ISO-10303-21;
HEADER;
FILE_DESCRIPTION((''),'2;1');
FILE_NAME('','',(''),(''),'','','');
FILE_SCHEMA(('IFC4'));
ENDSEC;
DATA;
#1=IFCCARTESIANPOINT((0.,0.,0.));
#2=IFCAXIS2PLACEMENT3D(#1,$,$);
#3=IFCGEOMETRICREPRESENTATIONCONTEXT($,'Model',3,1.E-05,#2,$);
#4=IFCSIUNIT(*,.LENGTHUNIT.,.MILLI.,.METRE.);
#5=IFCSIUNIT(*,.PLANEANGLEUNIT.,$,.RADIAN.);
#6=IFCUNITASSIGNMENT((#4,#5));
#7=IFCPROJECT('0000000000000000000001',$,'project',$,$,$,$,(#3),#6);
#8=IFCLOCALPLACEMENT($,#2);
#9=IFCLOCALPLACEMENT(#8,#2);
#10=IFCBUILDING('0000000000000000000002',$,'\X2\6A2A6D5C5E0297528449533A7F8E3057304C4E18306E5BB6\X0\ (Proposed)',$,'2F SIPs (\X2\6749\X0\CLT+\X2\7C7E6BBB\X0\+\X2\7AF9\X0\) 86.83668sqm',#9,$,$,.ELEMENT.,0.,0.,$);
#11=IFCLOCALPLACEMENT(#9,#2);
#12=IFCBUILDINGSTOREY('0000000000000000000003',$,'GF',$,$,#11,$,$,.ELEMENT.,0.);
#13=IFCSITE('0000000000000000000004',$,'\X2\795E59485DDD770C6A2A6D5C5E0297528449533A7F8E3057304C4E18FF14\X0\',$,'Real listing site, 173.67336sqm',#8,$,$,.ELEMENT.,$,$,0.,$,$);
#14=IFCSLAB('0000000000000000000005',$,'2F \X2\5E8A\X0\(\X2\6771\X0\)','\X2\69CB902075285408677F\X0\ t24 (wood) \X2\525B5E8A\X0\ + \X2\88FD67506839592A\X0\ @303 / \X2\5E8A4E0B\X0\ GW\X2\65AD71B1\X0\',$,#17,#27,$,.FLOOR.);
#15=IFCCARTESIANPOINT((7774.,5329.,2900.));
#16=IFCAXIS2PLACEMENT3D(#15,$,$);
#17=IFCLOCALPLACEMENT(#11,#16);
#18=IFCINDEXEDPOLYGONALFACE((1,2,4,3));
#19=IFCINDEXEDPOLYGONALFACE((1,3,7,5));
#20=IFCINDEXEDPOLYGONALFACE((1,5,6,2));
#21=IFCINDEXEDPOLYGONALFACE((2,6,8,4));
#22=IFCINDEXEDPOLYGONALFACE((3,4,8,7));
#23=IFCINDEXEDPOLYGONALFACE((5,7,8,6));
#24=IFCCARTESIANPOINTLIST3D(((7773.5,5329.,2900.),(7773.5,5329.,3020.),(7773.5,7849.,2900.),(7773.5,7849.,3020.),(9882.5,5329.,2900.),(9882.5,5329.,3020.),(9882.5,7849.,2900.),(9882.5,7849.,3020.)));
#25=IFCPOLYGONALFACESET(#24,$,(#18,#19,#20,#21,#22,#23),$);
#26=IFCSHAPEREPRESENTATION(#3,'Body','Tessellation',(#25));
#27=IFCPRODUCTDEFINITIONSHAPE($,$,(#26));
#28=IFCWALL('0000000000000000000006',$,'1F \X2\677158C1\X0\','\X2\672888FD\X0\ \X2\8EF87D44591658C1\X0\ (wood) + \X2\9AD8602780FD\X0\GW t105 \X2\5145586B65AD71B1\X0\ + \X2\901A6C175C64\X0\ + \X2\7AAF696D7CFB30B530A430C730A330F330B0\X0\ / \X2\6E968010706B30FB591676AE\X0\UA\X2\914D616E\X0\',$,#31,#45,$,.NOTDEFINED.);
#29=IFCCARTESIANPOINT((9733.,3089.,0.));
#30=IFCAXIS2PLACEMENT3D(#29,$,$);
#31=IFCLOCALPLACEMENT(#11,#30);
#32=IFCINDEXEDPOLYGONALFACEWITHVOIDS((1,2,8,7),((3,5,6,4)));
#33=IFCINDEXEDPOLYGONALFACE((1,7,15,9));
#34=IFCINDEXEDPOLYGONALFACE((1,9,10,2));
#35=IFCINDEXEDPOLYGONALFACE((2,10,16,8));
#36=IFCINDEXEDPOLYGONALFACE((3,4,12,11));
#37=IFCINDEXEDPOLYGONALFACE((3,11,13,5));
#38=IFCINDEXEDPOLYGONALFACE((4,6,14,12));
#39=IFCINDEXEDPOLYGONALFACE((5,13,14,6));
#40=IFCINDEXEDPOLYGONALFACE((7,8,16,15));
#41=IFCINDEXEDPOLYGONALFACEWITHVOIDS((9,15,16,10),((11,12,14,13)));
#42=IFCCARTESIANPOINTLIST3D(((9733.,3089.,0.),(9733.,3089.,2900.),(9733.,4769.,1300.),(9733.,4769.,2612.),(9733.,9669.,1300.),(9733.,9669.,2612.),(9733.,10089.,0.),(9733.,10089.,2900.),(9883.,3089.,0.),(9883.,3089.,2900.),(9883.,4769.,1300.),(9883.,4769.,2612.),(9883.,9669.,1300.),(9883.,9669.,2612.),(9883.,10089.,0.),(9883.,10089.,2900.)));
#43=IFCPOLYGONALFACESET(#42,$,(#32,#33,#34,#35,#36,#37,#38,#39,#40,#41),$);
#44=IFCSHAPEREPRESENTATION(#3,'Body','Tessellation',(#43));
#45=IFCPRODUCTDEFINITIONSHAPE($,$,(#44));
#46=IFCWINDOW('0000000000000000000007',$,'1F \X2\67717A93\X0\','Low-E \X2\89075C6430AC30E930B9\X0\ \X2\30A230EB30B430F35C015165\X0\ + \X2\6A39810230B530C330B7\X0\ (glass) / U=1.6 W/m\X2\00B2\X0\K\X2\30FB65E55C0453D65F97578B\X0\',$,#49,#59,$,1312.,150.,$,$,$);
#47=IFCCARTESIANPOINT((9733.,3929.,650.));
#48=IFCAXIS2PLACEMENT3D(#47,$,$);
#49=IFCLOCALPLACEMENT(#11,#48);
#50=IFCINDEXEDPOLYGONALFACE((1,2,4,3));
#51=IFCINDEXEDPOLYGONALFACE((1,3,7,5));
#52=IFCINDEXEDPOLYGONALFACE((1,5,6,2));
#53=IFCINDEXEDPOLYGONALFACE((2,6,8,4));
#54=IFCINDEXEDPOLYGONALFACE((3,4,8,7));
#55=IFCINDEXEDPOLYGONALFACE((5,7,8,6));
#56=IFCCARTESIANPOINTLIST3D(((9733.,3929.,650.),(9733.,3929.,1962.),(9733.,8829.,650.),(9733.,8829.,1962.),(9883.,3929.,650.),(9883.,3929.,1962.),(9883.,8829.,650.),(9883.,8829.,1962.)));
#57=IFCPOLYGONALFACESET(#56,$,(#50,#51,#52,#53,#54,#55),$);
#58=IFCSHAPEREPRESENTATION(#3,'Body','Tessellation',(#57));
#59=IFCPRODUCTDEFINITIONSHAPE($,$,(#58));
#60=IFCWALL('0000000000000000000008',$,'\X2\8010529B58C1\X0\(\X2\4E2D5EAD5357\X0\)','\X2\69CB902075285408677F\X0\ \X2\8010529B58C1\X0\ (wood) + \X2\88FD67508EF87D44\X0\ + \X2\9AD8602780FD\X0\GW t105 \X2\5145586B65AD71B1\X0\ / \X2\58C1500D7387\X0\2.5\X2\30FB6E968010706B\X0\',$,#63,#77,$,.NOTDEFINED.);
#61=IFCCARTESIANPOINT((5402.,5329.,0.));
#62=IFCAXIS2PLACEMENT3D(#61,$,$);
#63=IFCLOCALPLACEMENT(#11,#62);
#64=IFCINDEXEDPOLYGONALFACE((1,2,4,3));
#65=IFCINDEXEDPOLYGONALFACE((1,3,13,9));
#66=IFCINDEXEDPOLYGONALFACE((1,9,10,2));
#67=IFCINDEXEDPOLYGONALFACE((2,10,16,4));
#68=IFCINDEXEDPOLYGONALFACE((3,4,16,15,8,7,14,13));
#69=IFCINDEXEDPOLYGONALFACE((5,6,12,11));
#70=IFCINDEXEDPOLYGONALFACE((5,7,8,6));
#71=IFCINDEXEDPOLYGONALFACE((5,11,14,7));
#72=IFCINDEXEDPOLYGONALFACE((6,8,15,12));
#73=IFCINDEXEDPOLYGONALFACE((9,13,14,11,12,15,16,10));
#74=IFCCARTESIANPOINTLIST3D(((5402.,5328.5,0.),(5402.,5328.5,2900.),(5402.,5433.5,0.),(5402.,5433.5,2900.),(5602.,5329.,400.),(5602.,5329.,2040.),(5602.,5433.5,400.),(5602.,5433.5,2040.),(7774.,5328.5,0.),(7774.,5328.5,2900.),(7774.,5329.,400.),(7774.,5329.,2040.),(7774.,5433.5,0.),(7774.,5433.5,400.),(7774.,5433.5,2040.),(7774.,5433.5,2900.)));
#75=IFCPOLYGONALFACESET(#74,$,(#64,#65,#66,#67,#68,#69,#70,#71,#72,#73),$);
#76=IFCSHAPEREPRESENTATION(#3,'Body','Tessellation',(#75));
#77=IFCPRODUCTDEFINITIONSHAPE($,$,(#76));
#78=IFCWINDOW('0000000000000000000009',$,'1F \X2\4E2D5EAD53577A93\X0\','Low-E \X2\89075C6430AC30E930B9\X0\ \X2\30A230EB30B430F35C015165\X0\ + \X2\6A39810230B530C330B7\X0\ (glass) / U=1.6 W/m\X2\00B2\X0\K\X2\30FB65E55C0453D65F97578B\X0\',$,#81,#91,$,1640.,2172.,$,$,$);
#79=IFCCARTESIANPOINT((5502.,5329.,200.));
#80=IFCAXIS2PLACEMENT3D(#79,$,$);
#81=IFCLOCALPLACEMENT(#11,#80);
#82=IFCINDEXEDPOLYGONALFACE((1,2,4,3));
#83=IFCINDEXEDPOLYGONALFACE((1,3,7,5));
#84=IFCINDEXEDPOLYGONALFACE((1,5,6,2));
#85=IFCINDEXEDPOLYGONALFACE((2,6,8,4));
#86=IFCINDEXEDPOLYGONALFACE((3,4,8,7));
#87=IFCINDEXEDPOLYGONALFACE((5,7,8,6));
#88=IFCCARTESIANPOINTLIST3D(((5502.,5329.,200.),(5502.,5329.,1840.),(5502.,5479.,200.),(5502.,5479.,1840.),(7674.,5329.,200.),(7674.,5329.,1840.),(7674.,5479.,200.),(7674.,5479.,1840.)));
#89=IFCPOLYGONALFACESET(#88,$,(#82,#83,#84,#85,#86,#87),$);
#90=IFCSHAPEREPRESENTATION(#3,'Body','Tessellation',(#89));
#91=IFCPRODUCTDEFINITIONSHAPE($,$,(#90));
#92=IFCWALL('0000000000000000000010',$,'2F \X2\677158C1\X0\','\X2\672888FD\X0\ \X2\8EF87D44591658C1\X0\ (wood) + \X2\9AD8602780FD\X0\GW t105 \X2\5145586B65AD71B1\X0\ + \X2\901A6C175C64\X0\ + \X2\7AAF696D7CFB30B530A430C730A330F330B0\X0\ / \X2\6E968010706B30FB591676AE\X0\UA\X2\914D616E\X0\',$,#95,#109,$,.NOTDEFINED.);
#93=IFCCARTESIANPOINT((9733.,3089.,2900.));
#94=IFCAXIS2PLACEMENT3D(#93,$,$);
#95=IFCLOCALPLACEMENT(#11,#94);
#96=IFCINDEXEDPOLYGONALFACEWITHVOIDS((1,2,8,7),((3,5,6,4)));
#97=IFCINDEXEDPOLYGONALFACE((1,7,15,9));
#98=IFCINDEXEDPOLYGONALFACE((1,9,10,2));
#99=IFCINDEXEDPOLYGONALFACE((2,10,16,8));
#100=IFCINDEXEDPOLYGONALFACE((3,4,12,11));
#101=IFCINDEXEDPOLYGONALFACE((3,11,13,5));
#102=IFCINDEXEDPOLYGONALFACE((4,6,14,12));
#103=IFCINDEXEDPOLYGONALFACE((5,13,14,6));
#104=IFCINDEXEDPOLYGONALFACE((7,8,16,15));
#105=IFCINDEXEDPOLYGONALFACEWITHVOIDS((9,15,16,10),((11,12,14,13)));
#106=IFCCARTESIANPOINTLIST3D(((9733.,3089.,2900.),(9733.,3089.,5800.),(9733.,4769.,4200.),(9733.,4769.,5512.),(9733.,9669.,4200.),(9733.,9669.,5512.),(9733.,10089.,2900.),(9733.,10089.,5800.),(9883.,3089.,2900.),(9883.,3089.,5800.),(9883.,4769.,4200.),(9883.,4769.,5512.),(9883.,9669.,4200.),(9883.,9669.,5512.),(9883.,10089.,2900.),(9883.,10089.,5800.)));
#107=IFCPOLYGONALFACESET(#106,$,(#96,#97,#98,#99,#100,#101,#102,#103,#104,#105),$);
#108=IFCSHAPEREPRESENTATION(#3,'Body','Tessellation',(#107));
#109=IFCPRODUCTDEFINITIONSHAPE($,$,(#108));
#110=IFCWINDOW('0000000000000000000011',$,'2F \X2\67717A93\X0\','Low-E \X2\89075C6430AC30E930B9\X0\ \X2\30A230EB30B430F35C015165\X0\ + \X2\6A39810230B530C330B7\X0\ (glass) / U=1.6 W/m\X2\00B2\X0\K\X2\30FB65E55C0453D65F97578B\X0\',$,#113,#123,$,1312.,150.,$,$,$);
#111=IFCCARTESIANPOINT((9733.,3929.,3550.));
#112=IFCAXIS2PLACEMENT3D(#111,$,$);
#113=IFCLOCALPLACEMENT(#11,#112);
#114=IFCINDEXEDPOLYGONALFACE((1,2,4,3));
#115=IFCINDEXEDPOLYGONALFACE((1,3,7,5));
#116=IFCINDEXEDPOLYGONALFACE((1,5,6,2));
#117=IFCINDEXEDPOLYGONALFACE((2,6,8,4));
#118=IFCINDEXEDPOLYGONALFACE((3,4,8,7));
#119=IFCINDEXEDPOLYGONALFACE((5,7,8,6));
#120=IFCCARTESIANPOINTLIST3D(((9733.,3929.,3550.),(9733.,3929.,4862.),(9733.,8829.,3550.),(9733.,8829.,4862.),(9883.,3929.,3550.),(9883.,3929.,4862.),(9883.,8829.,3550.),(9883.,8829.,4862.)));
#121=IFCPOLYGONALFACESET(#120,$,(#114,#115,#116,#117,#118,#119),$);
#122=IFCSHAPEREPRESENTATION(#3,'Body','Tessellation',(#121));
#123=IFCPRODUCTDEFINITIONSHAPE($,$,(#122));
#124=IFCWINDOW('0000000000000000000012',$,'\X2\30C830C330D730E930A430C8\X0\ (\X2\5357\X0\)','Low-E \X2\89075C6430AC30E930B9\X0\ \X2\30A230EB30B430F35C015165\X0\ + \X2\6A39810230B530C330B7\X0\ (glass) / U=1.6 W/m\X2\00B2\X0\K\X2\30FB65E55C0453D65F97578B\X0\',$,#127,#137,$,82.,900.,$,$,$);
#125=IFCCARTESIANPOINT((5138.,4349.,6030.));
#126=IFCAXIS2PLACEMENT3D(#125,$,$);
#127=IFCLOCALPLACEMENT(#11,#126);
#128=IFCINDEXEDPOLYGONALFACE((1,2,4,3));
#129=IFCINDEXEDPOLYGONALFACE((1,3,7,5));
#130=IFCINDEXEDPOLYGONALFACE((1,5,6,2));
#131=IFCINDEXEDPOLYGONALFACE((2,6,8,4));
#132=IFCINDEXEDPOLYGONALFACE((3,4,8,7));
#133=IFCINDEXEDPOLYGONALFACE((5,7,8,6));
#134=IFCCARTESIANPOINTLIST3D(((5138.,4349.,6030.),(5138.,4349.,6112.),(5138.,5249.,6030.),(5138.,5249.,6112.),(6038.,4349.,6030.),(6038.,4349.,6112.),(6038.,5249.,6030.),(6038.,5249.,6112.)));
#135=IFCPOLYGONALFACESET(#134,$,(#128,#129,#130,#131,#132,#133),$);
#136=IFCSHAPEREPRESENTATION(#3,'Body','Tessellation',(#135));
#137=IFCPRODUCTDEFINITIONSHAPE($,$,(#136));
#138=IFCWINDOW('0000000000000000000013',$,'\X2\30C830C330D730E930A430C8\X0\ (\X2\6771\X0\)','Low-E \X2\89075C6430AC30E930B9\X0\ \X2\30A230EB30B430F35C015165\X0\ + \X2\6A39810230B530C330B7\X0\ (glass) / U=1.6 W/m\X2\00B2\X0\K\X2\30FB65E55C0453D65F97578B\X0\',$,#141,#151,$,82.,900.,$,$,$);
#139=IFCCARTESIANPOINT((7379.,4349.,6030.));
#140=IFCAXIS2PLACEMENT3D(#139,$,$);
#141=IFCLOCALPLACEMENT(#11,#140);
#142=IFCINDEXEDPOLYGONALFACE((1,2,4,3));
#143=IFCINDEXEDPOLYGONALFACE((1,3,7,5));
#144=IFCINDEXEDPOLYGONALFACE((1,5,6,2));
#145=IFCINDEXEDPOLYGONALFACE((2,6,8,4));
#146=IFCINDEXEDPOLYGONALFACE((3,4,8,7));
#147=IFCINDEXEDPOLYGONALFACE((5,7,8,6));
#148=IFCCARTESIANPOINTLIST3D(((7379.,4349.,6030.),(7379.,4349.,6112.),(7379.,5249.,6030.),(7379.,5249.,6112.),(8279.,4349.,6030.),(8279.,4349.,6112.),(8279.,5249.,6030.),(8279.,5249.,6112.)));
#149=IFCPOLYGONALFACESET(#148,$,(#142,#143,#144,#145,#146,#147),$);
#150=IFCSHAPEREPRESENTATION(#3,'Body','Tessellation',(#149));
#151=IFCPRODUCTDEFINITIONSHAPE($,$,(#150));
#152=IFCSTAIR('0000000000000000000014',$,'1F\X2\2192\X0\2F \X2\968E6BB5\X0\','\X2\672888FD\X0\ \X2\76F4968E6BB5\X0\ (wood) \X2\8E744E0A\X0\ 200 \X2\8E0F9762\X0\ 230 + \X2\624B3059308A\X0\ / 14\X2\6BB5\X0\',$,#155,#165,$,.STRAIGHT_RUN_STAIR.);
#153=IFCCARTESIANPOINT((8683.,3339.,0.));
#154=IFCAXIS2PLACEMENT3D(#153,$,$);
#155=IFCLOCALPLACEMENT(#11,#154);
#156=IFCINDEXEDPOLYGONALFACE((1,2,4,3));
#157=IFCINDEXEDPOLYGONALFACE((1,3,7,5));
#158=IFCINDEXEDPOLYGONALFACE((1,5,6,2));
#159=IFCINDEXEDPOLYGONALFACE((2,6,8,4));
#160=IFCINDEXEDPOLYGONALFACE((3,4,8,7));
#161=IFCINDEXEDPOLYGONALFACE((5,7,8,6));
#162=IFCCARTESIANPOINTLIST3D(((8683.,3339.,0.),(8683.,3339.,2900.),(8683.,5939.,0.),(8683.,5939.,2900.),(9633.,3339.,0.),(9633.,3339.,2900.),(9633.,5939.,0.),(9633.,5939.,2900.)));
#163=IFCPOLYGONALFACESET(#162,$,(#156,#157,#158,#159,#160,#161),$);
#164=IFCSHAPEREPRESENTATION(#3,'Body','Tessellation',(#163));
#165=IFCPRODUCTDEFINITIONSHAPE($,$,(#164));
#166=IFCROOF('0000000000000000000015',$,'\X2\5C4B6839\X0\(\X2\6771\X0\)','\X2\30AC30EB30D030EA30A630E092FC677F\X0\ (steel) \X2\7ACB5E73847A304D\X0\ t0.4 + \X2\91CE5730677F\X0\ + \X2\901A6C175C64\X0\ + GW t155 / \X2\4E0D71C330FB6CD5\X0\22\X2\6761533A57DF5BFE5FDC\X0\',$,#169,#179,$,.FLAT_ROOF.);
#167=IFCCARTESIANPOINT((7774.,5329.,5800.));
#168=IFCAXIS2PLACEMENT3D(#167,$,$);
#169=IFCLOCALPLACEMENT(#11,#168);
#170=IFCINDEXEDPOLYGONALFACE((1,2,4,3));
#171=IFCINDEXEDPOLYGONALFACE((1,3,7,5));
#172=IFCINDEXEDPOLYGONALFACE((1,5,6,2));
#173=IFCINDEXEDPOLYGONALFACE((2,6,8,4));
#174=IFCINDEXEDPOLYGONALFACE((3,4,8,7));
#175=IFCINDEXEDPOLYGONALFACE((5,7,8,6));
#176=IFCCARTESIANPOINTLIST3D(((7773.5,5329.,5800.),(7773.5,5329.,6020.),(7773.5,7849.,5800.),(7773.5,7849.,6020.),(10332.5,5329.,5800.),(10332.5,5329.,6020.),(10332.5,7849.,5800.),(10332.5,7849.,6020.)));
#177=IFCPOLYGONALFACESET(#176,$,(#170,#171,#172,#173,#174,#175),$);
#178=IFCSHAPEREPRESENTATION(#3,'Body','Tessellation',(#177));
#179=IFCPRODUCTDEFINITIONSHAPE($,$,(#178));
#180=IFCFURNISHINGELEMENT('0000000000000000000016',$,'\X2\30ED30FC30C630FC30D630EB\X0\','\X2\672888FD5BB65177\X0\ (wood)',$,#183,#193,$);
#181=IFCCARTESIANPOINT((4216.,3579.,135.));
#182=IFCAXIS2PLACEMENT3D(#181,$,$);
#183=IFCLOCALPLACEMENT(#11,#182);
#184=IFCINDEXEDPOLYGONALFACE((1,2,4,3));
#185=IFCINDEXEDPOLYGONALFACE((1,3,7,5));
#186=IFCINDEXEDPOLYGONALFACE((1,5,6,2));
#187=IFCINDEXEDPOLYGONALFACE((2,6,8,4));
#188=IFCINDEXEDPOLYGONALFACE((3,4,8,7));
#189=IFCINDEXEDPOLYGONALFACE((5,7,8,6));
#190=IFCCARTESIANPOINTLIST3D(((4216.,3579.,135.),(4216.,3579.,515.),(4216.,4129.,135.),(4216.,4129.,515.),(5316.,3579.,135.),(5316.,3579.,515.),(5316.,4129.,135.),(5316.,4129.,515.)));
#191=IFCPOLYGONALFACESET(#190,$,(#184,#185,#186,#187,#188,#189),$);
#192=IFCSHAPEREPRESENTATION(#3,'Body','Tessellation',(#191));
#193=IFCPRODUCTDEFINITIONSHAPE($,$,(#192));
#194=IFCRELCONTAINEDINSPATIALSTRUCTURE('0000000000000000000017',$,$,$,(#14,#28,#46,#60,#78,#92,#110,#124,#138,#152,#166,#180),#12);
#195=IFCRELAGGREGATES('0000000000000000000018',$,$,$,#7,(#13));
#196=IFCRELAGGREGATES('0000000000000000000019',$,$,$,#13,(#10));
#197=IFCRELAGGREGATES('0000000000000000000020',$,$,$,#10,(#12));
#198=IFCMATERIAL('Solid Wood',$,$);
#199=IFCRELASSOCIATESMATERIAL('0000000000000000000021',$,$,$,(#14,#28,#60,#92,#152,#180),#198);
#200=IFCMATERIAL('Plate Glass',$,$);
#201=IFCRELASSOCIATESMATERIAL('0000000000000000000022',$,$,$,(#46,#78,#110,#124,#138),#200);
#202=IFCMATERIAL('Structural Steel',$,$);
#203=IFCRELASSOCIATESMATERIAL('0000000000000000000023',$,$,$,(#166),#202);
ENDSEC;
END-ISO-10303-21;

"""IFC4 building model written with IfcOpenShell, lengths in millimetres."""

from ifc_helpers import new_model, si_unit, frame, frame_2d, origin, place, context, project, spatial, rectangle, extrude, material, element, fill, save


model = new_model("IFC4")

# Units and contexts
model_context = context("Model", 3, precision=1e-05, world=origin())
ifc_project = project(units=[si_unit("LENGTHUNIT", "METRE", prefix="MILLI"), si_unit("PLANEANGLEUNIT", "RADIAN")], contexts=[model_context])

# Site, building, storey
site_placement = place(None, origin())
site = spatial("IfcSite", under=ifc_project, at=site_placement, Name="神奈川県横浜市青葉区美しが丘４", ObjectType="Real listing site, 173.67336sqm", CompositionType="ELEMENT", RefElevation=0.0)
building_placement = place(site_placement, origin())
building = spatial("IfcBuilding", under=site, at=building_placement, Name="横浜市青葉区美しが丘の家 (Proposed)", ObjectType="2F SIPs (杉CLT+籾殻+竹) 86.83668sqm", CompositionType="ELEMENT", ElevationOfRefHeight=0.0, ElevationOfTerrain=0.0)
storey_placement = place(building_placement, origin())
storey = spatial("IfcBuildingStorey", under=building, at=storey_placement, Name="GF", CompositionType="ELEMENT", Elevation=0.0)

# Slab
ifc_material_1 = material(Name="Solid Wood")
slab_1_placement = place(storey_placement, frame((7774.0, 5329.0, 2900.0)))
element("IfcSlab", 1, at=slab_1_placement, inside=storey, material=ifc_material_1, Name="2F 床(東)", Description="構造用合板 t24 (wood) 剛床 + 製材根太 @303 / 床下 GW断熱", PredefinedType="FLOOR", context=model_context, shape_type="SweptSolid", body=[
    extrude(rectangle(XDim=2109.0, YDim=2520.0, at=frame_2d((1054.0, 1260.0))), frame((7774.0, 5329.0, 2900.0)), (0.0, 0.0, 1.0), 120.0),
])

# Walls, openings, windows
wall_1_placement = place(storey_placement, frame((9733.0, 3089.0, 0.0)))
wall_1 = element("IfcWall", 2, at=wall_1_placement, inside=storey, material=ifc_material_1, Name="1F 東壁", Description="木製 軸組外壁 (wood) + 高性能GW t105 充填断熱 + 通気層 + 窯業系サイディング / 準耐火・外皮UA配慮", PredefinedType="NOTDEFINED", context=model_context, shape_type="SweptSolid", body=[
    extrude(rectangle(XDim=150.0, YDim=7000.0, at=frame_2d((75.0, 3500.0))), frame((9733.0, 3089.0, 0.0)), (0.0, 0.0, 1.0), 2900.0),
])
opening_1_placement = place(storey_placement, frame((9733.0, 3929.0, 650.0)))
opening_1 = element("IfcOpeningElement", 3, at=opening_1_placement, cuts=wall_1, PredefinedType="NOTDEFINED", context=model_context, shape_type="SweptSolid", body=[
    extrude(rectangle(XDim=150.0, YDim=4900.0, at=frame_2d((75.0, 2450.0))), frame((9733.0, 3929.0, 650.0)), (0.0, 0.0, 1.0), 1312.0),
])
ifc_material_2 = material(Name="Plate Glass")
window_1_placement = place(storey_placement, frame((9733.0, 3929.0, 650.0)))
window_1 = element("IfcWindow", 4, at=window_1_placement, inside=storey, material=ifc_material_2, Name="1F 東窓", Description="Low-E 複層ガラス アルゴン封入 + 樹脂サッシ (glass) / U=1.6 W/m²K・日射取得型", OverallHeight=1312.0, OverallWidth=150.0, context=model_context, shape_type="SweptSolid", body=[
    extrude(rectangle(XDim=150.0, YDim=4900.0, at=frame_2d((75.0, 2450.0))), frame((9733.0, 3929.0, 650.0)), (0.0, 0.0, 1.0), 1312.0),
])
fill(opening_1, window_1)
wall_2_placement = place(storey_placement, frame((5402.0, 5329.0, 0.0)))
wall_2 = element("IfcWall", 5, at=wall_2_placement, inside=storey, material=ifc_material_1, Name="耐力壁(中庭南)", Description="構造用合板 耐力壁 (wood) + 製材軸組 + 高性能GW t105 充填断熱 / 壁倍率2.5・準耐火", PredefinedType="NOTDEFINED", context=model_context, shape_type="SweptSolid", body=[
    extrude(rectangle(XDim=2372.0, YDim=105.0, at=frame_2d((1186.0, 52.0))), frame((5402.0, 5329.0, 0.0)), (0.0, 0.0, 1.0), 2900.0),
])
opening_2_placement = place(storey_placement, frame((5502.0, 5329.0, 200.0)))
opening_2 = element("IfcOpeningElement", 6, at=opening_2_placement, cuts=wall_2, PredefinedType="NOTDEFINED", context=model_context, shape_type="SweptSolid", body=[
    extrude(rectangle(XDim=2172.0, YDim=150.0, at=frame_2d((1086.0, 75.0))), frame((5502.0, 5329.0, 200.0)), (0.0, 0.0, 1.0), 1640.0),
])
window_2_placement = place(storey_placement, frame((5502.0, 5329.0, 200.0)))
window_2 = element("IfcWindow", 7, at=window_2_placement, inside=storey, material=ifc_material_2, Name="1F 中庭南窓", Description="Low-E 複層ガラス アルゴン封入 + 樹脂サッシ (glass) / U=1.6 W/m²K・日射取得型", OverallHeight=1640.0, OverallWidth=2172.0, context=model_context, shape_type="SweptSolid", body=[
    extrude(rectangle(XDim=2172.0, YDim=150.0, at=frame_2d((1086.0, 75.0))), frame((5502.0, 5329.0, 200.0)), (0.0, 0.0, 1.0), 1640.0),
])
fill(opening_2, window_2)

# Wall, opening, window
wall_3_placement = place(storey_placement, frame((9733.0, 3089.0, 2900.0)))
wall_3 = element("IfcWall", 8, at=wall_3_placement, inside=storey, material=ifc_material_1, Name="2F 東壁", Description="木製 軸組外壁 (wood) + 高性能GW t105 充填断熱 + 通気層 + 窯業系サイディング / 準耐火・外皮UA配慮", PredefinedType="NOTDEFINED", context=model_context, shape_type="SweptSolid", body=[
    extrude(rectangle(XDim=150.0, YDim=7000.0, at=frame_2d((75.0, 3500.0))), frame((9733.0, 3089.0, 2900.0)), (0.0, 0.0, 1.0), 2900.0),
])
opening_3_placement = place(storey_placement, frame((9733.0, 3929.0, 3550.0)))
opening_3 = element("IfcOpeningElement", 9, at=opening_3_placement, cuts=wall_3, PredefinedType="NOTDEFINED", context=model_context, shape_type="SweptSolid", body=[
    extrude(rectangle(XDim=150.0, YDim=4900.0, at=frame_2d((75.0, 2450.0))), frame((9733.0, 3929.0, 3550.0)), (0.0, 0.0, 1.0), 1312.0),
])
window_3_placement = place(storey_placement, frame((9733.0, 3929.0, 3550.0)))
window_3 = element("IfcWindow", 10, at=window_3_placement, inside=storey, material=ifc_material_2, Name="2F 東窓", Description="Low-E 複層ガラス アルゴン封入 + 樹脂サッシ (glass) / U=1.6 W/m²K・日射取得型", OverallHeight=1312.0, OverallWidth=150.0, context=model_context, shape_type="SweptSolid", body=[
    extrude(rectangle(XDim=150.0, YDim=4900.0, at=frame_2d((75.0, 2450.0))), frame((9733.0, 3929.0, 3550.0)), (0.0, 0.0, 1.0), 1312.0),
])
fill(opening_3, window_3)

# Windows
window_4_placement = place(storey_placement, frame((5138.0, 4349.0, 6030.0)))
element("IfcWindow", 11, at=window_4_placement, inside=storey, material=ifc_material_2, Name="トップライト (南)", Description="Low-E 複層ガラス アルゴン封入 + 樹脂サッシ (glass) / U=1.6 W/m²K・日射取得型", OverallHeight=82.0, OverallWidth=900.0, context=model_context, shape_type="SweptSolid", body=[
    extrude(rectangle(XDim=900.0, YDim=900.0, at=frame_2d((450.0, 450.0))), frame((5138.0, 4349.0, 6030.0)), (0.0, 0.0, 1.0), 82.0),
])
window_5_placement = place(storey_placement, frame((7379.0, 4349.0, 6030.0)))
element("IfcWindow", 12, at=window_5_placement, inside=storey, material=ifc_material_2, Name="トップライト (東)", Description="Low-E 複層ガラス アルゴン封入 + 樹脂サッシ (glass) / U=1.6 W/m²K・日射取得型", OverallHeight=82.0, OverallWidth=900.0, context=model_context, shape_type="SweptSolid", body=[
    extrude(rectangle(XDim=900.0, YDim=900.0, at=frame_2d((450.0, 450.0))), frame((7379.0, 4349.0, 6030.0)), (0.0, 0.0, 1.0), 82.0),
])

# Stair
stair_placement = place(storey_placement, frame((8683.0, 3339.0, 0.0)))
element("IfcStair", 13, at=stair_placement, inside=storey, material=ifc_material_1, Name="1F→2F 階段", Description="木製 直階段 (wood) 蹴上 200 踏面 230 + 手すり / 14段", PredefinedType="STRAIGHT_RUN_STAIR", context=model_context, shape_type="SweptSolid", body=[
    extrude(rectangle(XDim=950.0, YDim=2600.0, at=frame_2d((475.0, 1300.0))), frame((8683.0, 3339.0, 0.0)), (0.0, 0.0, 1.0), 2900.0),
])

# Roof
ifc_material_3 = material(Name="Structural Steel")
roof_placement = place(storey_placement, frame((7774.0, 5329.0, 5800.0)))
element("IfcRoof", 14, at=roof_placement, inside=storey, material=ifc_material_3, Name="屋根(東)", Description="ガルバリウム鋼板 (steel) 立平葺き t0.4 + 野地板 + 通気層 + GW t155 / 不燃・法22条区域対応", PredefinedType="FLAT_ROOF", context=model_context, shape_type="SweptSolid", body=[
    extrude(rectangle(XDim=2559.0, YDim=2520.0, at=frame_2d((1279.0, 1260.0))), frame((7774.0, 5329.0, 5800.0)), (0.0, 0.0, 1.0), 220.0),
])

# Furnishing element
furnishing_1_placement = place(storey_placement, frame((4216.0, 3579.0, 135.0)))
element("IfcFurnishingElement", 15, at=furnishing_1_placement, inside=storey, material=ifc_material_1, Name="ローテーブル", Description="木製家具 (wood)", context=model_context, shape_type="SweptSolid", body=[
    extrude(rectangle(XDim=1100.0, YDim=550.0, at=frame_2d((550.0, 275.0))), frame((4216.0, 3579.0, 135.0)), (0.0, 0.0, 1.0), 380.0),
])

save(model, "model.ifc")
